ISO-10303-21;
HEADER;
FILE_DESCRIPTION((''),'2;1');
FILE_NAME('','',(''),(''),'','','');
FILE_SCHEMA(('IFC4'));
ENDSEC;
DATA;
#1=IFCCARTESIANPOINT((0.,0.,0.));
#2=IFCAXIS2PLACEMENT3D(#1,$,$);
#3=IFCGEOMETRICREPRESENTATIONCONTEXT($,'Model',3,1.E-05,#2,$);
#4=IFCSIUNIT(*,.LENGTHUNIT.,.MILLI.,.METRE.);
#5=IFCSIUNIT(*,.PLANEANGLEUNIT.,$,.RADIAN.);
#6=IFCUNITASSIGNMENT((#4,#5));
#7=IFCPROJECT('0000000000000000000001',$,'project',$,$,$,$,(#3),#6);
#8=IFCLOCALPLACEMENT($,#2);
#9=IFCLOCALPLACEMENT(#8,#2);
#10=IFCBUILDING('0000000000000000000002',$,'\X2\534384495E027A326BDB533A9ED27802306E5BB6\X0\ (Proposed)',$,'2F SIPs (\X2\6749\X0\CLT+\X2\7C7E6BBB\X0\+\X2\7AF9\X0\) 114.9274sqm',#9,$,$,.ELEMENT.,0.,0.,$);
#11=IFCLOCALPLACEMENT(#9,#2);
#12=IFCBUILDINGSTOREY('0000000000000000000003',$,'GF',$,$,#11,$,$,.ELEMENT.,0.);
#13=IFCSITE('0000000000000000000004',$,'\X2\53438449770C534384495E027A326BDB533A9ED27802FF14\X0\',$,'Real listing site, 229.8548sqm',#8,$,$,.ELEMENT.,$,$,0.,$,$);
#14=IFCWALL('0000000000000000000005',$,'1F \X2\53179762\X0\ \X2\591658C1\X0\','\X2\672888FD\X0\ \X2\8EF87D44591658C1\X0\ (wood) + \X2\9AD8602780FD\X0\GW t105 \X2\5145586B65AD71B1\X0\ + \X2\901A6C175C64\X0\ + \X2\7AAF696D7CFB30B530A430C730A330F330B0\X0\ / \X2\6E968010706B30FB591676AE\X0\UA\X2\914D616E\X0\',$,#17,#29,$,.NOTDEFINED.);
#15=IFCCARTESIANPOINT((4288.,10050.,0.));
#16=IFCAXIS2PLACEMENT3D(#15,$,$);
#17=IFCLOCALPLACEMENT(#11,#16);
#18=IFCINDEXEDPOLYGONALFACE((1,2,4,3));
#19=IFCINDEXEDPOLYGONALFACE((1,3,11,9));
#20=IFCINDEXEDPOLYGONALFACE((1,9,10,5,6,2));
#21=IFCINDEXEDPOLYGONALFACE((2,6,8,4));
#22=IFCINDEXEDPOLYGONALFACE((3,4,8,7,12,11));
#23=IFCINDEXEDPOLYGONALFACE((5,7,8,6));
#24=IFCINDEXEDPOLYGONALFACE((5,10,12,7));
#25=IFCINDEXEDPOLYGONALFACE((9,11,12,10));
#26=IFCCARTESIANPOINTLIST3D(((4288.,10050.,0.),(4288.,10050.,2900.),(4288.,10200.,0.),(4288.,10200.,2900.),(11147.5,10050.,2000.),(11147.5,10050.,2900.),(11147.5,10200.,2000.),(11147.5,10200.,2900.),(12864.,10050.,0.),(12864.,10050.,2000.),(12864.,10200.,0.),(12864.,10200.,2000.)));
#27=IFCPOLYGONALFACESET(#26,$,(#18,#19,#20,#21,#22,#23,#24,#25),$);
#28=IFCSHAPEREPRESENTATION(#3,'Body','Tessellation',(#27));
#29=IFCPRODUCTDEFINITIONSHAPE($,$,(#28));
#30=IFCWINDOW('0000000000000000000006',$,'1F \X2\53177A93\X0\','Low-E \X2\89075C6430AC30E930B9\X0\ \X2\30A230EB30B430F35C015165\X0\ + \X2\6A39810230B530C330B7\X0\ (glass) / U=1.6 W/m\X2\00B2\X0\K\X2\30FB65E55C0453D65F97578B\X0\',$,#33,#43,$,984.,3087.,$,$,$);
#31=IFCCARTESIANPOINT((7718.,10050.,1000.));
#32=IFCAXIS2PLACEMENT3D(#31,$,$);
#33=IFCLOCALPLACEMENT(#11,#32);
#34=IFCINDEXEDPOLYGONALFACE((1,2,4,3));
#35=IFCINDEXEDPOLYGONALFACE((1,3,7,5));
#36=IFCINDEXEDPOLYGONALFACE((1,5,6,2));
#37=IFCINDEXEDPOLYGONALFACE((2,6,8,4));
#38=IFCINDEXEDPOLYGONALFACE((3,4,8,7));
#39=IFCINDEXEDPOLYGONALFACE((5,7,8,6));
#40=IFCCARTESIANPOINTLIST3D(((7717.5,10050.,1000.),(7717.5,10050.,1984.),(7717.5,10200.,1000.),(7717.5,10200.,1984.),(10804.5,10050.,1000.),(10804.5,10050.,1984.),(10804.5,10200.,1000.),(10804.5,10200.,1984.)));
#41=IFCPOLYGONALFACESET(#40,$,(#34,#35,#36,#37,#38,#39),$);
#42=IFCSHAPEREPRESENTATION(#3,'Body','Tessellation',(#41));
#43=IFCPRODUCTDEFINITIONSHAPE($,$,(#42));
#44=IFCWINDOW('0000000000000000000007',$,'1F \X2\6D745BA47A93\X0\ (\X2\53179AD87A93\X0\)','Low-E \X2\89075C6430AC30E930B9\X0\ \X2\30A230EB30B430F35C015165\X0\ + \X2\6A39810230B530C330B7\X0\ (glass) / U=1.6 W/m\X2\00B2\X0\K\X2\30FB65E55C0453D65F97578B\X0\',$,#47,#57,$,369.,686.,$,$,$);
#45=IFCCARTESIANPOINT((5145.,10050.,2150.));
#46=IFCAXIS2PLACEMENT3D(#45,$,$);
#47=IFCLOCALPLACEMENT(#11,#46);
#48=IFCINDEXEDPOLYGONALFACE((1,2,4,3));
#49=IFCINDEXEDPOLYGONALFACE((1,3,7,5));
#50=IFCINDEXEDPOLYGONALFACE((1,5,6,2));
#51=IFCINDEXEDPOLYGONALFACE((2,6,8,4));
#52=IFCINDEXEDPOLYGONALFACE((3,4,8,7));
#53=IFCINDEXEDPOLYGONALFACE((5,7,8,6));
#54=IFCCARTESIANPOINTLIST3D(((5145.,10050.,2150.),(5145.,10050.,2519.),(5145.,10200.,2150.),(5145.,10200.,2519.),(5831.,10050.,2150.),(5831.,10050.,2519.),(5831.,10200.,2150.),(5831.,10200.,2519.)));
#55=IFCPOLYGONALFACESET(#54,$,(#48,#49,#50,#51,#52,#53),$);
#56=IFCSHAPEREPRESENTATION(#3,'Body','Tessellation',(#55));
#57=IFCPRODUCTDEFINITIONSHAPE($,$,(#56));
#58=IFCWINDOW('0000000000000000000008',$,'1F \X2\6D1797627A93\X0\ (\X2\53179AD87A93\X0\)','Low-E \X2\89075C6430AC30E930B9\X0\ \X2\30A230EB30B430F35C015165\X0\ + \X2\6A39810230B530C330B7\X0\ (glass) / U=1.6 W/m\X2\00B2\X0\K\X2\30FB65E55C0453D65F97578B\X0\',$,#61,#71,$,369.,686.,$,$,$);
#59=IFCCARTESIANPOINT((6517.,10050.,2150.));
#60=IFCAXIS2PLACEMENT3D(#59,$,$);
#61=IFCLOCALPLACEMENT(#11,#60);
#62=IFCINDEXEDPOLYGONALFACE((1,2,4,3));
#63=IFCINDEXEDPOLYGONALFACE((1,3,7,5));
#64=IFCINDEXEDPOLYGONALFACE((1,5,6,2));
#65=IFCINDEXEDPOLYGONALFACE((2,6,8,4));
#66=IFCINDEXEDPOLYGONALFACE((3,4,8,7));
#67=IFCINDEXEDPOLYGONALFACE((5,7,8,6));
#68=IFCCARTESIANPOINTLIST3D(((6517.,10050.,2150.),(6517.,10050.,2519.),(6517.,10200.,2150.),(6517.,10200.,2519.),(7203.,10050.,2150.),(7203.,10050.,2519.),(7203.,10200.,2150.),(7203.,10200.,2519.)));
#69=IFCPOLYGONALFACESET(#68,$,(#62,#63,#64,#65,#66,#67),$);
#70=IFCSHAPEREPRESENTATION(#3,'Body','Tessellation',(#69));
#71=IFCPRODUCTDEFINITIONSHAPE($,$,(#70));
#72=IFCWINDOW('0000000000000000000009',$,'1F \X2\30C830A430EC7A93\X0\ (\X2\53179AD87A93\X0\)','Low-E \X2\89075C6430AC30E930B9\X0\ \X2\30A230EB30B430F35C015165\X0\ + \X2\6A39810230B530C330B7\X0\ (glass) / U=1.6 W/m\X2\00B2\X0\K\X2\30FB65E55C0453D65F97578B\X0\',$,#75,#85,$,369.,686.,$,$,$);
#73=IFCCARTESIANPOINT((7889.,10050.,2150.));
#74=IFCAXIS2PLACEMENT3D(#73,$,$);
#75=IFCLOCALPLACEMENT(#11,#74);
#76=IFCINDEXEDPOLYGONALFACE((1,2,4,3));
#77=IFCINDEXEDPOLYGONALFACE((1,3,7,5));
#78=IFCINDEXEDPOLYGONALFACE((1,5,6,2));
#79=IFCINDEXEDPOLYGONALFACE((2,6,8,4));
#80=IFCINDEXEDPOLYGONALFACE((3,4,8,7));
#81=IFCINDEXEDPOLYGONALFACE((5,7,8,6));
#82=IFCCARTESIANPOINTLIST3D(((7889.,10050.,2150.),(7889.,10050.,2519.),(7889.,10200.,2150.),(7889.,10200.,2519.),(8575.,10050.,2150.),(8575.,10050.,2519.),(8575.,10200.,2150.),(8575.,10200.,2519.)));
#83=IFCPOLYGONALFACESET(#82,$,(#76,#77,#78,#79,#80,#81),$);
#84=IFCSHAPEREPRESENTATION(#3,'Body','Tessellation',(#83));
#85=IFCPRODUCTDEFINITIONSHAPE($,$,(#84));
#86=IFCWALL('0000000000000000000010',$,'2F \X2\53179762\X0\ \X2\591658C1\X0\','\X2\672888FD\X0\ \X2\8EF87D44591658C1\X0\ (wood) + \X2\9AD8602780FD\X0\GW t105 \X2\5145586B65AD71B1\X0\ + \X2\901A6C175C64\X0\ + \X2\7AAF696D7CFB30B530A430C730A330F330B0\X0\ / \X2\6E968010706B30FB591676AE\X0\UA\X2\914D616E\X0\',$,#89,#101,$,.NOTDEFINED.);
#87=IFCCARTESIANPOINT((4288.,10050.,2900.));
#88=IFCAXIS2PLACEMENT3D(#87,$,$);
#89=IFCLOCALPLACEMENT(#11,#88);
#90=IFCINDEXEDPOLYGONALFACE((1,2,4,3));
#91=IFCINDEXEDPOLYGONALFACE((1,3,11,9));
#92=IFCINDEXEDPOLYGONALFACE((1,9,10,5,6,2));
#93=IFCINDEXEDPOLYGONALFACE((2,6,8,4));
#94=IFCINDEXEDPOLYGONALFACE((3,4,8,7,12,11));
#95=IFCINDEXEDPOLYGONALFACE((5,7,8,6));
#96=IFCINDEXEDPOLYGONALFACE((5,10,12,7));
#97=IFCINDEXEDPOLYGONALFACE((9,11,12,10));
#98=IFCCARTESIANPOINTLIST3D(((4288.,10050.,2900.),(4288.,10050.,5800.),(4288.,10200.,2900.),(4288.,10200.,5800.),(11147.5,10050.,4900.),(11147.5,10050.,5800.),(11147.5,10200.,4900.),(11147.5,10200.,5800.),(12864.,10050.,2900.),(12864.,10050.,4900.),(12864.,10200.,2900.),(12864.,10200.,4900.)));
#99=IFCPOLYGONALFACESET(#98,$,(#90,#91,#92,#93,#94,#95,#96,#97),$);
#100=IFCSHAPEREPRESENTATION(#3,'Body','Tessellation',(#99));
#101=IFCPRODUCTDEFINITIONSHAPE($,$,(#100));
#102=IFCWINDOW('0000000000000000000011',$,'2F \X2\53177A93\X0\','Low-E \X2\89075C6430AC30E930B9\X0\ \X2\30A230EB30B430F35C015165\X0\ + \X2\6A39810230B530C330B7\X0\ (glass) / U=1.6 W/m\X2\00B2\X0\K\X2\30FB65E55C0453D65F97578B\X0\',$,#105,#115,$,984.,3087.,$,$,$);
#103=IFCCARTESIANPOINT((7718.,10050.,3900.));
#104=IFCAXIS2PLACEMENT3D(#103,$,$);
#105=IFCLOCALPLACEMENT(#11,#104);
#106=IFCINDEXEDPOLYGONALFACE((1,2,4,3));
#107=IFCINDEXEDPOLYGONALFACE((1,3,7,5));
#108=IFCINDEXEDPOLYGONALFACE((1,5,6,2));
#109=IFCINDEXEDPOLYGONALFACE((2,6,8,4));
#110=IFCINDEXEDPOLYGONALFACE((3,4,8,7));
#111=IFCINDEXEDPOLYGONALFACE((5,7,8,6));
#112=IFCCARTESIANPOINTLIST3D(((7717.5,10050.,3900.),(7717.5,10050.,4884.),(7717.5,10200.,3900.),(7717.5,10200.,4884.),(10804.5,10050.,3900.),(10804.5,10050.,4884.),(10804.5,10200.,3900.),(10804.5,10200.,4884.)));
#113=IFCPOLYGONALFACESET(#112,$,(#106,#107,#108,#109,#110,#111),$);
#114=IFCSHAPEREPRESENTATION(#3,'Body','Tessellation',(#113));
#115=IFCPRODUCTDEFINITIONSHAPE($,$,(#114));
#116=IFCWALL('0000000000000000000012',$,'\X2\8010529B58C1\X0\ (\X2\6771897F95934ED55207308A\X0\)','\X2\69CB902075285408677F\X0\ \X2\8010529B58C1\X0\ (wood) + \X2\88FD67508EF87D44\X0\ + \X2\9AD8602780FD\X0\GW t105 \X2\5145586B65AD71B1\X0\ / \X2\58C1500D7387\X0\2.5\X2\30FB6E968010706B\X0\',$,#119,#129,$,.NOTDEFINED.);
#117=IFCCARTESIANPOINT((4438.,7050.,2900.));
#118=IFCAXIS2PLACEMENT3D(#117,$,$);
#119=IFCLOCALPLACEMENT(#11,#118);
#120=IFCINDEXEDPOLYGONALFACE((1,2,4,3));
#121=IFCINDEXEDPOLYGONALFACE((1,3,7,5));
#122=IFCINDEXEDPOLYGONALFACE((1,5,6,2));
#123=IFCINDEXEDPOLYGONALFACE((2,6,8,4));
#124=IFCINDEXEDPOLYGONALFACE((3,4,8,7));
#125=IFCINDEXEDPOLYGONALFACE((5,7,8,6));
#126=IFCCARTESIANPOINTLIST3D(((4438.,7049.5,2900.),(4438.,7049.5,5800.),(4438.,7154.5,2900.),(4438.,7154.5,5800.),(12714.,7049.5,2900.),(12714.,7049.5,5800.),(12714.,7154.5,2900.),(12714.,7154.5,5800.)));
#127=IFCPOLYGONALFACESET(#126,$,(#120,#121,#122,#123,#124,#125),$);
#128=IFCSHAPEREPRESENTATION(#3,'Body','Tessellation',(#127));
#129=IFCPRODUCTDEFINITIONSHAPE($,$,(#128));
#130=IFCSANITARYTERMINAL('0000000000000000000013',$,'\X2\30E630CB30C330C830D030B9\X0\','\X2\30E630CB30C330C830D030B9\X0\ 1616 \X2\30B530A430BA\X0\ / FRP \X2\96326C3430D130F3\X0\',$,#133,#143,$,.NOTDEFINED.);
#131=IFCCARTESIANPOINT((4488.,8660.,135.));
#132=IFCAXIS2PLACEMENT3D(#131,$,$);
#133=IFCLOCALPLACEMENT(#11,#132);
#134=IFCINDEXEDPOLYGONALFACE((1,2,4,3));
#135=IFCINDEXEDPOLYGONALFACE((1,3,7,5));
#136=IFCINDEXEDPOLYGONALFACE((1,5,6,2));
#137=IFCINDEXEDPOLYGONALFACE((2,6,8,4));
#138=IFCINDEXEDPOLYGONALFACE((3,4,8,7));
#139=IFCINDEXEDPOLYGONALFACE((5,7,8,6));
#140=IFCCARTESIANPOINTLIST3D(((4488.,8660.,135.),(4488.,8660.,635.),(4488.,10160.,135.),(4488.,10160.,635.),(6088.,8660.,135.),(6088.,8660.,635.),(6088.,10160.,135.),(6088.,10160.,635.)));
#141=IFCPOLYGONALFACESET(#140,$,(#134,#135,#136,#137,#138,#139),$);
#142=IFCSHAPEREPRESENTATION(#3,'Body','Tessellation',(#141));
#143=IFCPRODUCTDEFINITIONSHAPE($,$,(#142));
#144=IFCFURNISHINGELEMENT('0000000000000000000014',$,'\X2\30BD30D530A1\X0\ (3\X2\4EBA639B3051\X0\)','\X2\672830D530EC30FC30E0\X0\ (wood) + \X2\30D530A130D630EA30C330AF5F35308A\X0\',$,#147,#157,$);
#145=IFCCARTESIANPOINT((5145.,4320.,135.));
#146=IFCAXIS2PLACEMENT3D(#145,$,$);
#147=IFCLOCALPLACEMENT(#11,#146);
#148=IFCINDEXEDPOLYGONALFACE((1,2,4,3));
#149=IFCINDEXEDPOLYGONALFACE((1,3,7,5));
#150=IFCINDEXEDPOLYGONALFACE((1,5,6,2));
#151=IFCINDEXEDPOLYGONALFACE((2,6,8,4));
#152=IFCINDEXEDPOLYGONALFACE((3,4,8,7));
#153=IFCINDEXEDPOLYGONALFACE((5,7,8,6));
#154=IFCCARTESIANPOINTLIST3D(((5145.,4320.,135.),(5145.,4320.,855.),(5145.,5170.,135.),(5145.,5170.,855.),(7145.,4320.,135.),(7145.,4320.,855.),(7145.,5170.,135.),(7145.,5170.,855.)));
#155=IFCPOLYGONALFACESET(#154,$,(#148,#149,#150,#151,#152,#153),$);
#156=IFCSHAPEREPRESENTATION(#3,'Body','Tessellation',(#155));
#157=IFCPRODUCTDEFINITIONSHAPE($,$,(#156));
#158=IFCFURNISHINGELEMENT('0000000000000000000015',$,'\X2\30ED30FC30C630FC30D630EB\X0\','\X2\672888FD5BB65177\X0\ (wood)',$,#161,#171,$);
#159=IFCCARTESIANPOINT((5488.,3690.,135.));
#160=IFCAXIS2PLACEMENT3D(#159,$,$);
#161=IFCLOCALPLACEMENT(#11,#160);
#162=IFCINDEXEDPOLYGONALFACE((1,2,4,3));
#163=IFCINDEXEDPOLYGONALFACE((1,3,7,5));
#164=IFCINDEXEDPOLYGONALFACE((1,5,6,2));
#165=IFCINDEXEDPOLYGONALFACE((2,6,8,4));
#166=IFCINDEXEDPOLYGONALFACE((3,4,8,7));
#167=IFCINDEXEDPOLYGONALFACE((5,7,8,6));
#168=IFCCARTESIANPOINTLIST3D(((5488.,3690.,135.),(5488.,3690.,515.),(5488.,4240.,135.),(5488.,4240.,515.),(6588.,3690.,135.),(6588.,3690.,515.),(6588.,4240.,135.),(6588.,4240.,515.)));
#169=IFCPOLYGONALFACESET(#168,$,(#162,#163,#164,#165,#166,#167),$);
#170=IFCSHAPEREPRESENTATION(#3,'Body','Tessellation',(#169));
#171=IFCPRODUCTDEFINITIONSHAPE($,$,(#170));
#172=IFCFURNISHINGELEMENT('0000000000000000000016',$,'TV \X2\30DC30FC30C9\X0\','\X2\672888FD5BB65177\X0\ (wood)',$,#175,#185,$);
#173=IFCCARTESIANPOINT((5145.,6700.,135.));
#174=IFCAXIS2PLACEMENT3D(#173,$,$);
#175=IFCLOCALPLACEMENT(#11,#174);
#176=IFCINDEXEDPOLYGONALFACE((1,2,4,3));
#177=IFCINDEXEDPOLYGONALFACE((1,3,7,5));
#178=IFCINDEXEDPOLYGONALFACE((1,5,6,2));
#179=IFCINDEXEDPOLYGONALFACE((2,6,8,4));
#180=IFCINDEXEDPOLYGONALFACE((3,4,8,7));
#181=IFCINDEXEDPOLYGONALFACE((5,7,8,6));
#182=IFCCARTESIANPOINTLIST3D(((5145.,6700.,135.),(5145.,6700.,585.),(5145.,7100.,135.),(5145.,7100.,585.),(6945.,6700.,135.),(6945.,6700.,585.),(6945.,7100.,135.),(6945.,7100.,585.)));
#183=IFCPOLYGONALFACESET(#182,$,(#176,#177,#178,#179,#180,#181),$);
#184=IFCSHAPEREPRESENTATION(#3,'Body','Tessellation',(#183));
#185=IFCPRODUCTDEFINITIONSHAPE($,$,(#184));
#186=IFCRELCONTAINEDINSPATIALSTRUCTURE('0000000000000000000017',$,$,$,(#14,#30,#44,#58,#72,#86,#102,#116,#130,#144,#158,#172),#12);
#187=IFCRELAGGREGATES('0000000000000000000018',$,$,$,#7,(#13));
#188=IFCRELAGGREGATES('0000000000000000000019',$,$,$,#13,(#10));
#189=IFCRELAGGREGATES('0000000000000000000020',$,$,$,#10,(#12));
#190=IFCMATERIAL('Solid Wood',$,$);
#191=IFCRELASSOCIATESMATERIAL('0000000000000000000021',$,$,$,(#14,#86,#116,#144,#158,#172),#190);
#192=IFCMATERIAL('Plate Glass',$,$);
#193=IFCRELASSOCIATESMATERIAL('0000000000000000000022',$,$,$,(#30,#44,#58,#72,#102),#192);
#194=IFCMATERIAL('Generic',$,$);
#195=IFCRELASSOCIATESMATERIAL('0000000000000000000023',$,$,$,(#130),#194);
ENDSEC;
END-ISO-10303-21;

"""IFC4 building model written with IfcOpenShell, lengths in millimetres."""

from ifc_helpers import new_model, si_unit, frame, frame_2d, origin, place, context, project, spatial, rectangle, extrude, material, element, fill, save


model = new_model("IFC4")

# Units and contexts
model_context = context("Model", 3, precision=1e-05, world=origin())
ifc_project = project(units=[si_unit("LENGTHUNIT", "METRE", prefix="MILLI"), si_unit("PLANEANGLEUNIT", "RADIAN")], contexts=[model_context])

# Site, building, storey
site_placement = place(None, origin())
site = spatial("IfcSite", under=ifc_project, at=site_placement, Name="千葉県千葉市稲毛区黒砂４", ObjectType="Real listing site, 229.8548sqm", CompositionType="ELEMENT", RefElevation=0.0)
building_placement = place(site_placement, origin())
building = spatial("IfcBuilding", under=site, at=building_placement, Name="千葉市稲毛区黒砂の家 (Proposed)", ObjectType="2F SIPs (杉CLT+籾殻+竹) 114.9274sqm", CompositionType="ELEMENT", ElevationOfRefHeight=0.0, ElevationOfTerrain=0.0)
storey_placement = place(building_placement, origin())
storey = spatial("IfcBuildingStorey", under=building, at=storey_placement, Name="GF", CompositionType="ELEMENT", Elevation=0.0)

# Wall, openings, windows
ifc_material_1 = material(Name="Solid Wood")
wall_1_placement = place(storey_placement, frame((4288.0, 10050.0, 0.0)))
wall_1 = element("IfcWall", 1, at=wall_1_placement, inside=storey, material=ifc_material_1, Name="1F 北面 外壁", Description="木製 軸組外壁 (wood) + 高性能GW t105 充填断熱 + 通気層 + 窯業系サイディング / 準耐火・外皮UA配慮", PredefinedType="NOTDEFINED", context=model_context, shape_type="SweptSolid", body=[
    extrude(rectangle(XDim=8576.0, YDim=150.0, at=frame_2d((4288.0, 75.0))), frame((4288.0, 10050.0, 0.0)), (0.0, 0.0, 1.0), 2900.0),
])
opening_1_placement = place(storey_placement, frame((7718.0, 10050.0, 1000.0)))
opening_1 = element("IfcOpeningElement", 2, at=opening_1_placement, cuts=wall_1, PredefinedType="NOTDEFINED", context=model_context, shape_type="SweptSolid", body=[
    extrude(rectangle(XDim=3087.0, YDim=150.0, at=frame_2d((1543.0, 75.0))), frame((7718.0, 10050.0, 1000.0)), (0.0, 0.0, 1.0), 984.0),
])
opening_2_placement = place(storey_placement, frame((5145.0, 10050.0, 2150.0)))
opening_2 = element("IfcOpeningElement", 3, at=opening_2_placement, cuts=wall_1, PredefinedType="NOTDEFINED", context=model_context, shape_type="SweptSolid", body=[
    extrude(rectangle(XDim=686.0, YDim=150.0, at=frame_2d((343.0, 75.0))), frame((5145.0, 10050.0, 2150.0)), (0.0, 0.0, 1.0), 369.0),
])
opening_3_placement = place(storey_placement, frame((6517.0, 10050.0, 2150.0)))
opening_3 = element("IfcOpeningElement", 4, at=opening_3_placement, cuts=wall_1, PredefinedType="NOTDEFINED", context=model_context, shape_type="SweptSolid", body=[
    extrude(rectangle(XDim=686.0, YDim=150.0, at=frame_2d((343.0, 75.0))), frame((6517.0, 10050.0, 2150.0)), (0.0, 0.0, 1.0), 369.0),
])
opening_4_placement = place(storey_placement, frame((7889.0, 10050.0, 2150.0)))
opening_4 = element("IfcOpeningElement", 5, at=opening_4_placement, cuts=wall_1, PredefinedType="NOTDEFINED", context=model_context, shape_type="SweptSolid", body=[
    extrude(rectangle(XDim=686.0, YDim=150.0, at=frame_2d((343.0, 75.0))), frame((7889.0, 10050.0, 2150.0)), (0.0, 0.0, 1.0), 369.0),
])
ifc_material_2 = material(Name="Plate Glass")
window_1_placement = place(storey_placement, frame((7718.0, 10050.0, 1000.0)))
window_1 = element("IfcWindow", 6, at=window_1_placement, inside=storey, material=ifc_material_2, Name="1F 北窓", Description="Low-E 複層ガラス アルゴン封入 + 樹脂サッシ (glass) / U=1.6 W/m²K・日射取得型", OverallHeight=984.0, OverallWidth=3087.0, context=model_context, shape_type="SweptSolid", body=[
    extrude(rectangle(XDim=3087.0, YDim=150.0, at=frame_2d((1543.0, 75.0))), frame((7718.0, 10050.0, 1000.0)), (0.0, 0.0, 1.0), 984.0),
])
fill(opening_1, window_1)
window_2_placement = place(storey_placement, frame((5145.0, 10050.0, 2150.0)))
window_2 = element("IfcWindow", 7, at=window_2_placement, inside=storey, material=ifc_material_2, Name="1F 浴室窓 (北高窓)", Description="Low-E 複層ガラス アルゴン封入 + 樹脂サッシ (glass) / U=1.6 W/m²K・日射取得型", OverallHeight=369.0, OverallWidth=686.0, context=model_context, shape_type="SweptSolid", body=[
    extrude(rectangle(XDim=686.0, YDim=150.0, at=frame_2d((343.0, 75.0))), frame((5145.0, 10050.0, 2150.0)), (0.0, 0.0, 1.0), 369.0),
])
fill(opening_2, window_2)
window_3_placement = place(storey_placement, frame((6517.0, 10050.0, 2150.0)))
window_3 = element("IfcWindow", 8, at=window_3_placement, inside=storey, material=ifc_material_2, Name="1F 洗面窓 (北高窓)", Description="Low-E 複層ガラス アルゴン封入 + 樹脂サッシ (glass) / U=1.6 W/m²K・日射取得型", OverallHeight=369.0, OverallWidth=686.0, context=model_context, shape_type="SweptSolid", body=[
    extrude(rectangle(XDim=686.0, YDim=150.0, at=frame_2d((343.0, 75.0))), frame((6517.0, 10050.0, 2150.0)), (0.0, 0.0, 1.0), 369.0),
])
fill(opening_3, window_3)
window_4_placement = place(storey_placement, frame((7889.0, 10050.0, 2150.0)))
window_4 = element("IfcWindow", 9, at=window_4_placement, inside=storey, material=ifc_material_2, Name="1F トイレ窓 (北高窓)", Description="Low-E 複層ガラス アルゴン封入 + 樹脂サッシ (glass) / U=1.6 W/m²K・日射取得型", OverallHeight=369.0, OverallWidth=686.0, context=model_context, shape_type="SweptSolid", body=[
    extrude(rectangle(XDim=686.0, YDim=150.0, at=frame_2d((343.0, 75.0))), frame((7889.0, 10050.0, 2150.0)), (0.0, 0.0, 1.0), 369.0),
])
fill(opening_4, window_4)

# Wall, opening, window
wall_2_placement = place(storey_placement, frame((4288.0, 10050.0, 2900.0)))
wall_2 = element("IfcWall", 10, at=wall_2_placement, inside=storey, material=ifc_material_1, Name="2F 北面 外壁", Description="木製 軸組外壁 (wood) + 高性能GW t105 充填断熱 + 通気層 + 窯業系サイディング / 準耐火・外皮UA配慮", PredefinedType="NOTDEFINED", context=model_context, shape_type="SweptSolid", body=[
    extrude(rectangle(XDim=8576.0, YDim=150.0, at=frame_2d((4288.0, 75.0))), frame((4288.0, 10050.0, 2900.0)), (0.0, 0.0, 1.0), 2900.0),
])
opening_5_placement = place(storey_placement, frame((7718.0, 10050.0, 3900.0)))
opening_5 = element("IfcOpeningElement", 11, at=opening_5_placement, cuts=wall_2, PredefinedType="NOTDEFINED", context=model_context, shape_type="SweptSolid", body=[
    extrude(rectangle(XDim=3087.0, YDim=150.0, at=frame_2d((1543.0, 75.0))), frame((7718.0, 10050.0, 3900.0)), (0.0, 0.0, 1.0), 984.0),
])
window_5_placement = place(storey_placement, frame((7718.0, 10050.0, 3900.0)))
window_5 = element("IfcWindow", 12, at=window_5_placement, inside=storey, material=ifc_material_2, Name="2F 北窓", Description="Low-E 複層ガラス アルゴン封入 + 樹脂サッシ (glass) / U=1.6 W/m²K・日射取得型", OverallHeight=984.0, OverallWidth=3087.0, context=model_context, shape_type="SweptSolid", body=[
    extrude(rectangle(XDim=3087.0, YDim=150.0, at=frame_2d((1543.0, 75.0))), frame((7718.0, 10050.0, 3900.0)), (0.0, 0.0, 1.0), 984.0),
])
fill(opening_5, window_5)

# Wall
wall_3_placement = place(storey_placement, frame((4438.0, 7050.0, 2900.0)))
element("IfcWall", 13, at=wall_3_placement, inside=storey, material=ifc_material_1, Name="耐力壁 (東西間仕切り)", Description="構造用合板 耐力壁 (wood) + 製材軸組 + 高性能GW t105 充填断熱 / 壁倍率2.5・準耐火", PredefinedType="NOTDEFINED", context=model_context, shape_type="SweptSolid", body=[
    extrude(rectangle(XDim=8276.0, YDim=105.0, at=frame_2d((4138.0, 52.0))), frame((4438.0, 7050.0, 2900.0)), (0.0, 0.0, 1.0), 2900.0),
])

# Sanitary terminal
ifc_material_3 = material(Name="Generic")
sanitary_terminal_placement = place(storey_placement, frame((4488.0, 8660.0, 135.0)))
element("IfcSanitaryTerminal", 14, at=sanitary_terminal_placement, inside=storey, material=ifc_material_3, Name="ユニットバス", Description="ユニットバス 1616 サイズ / FRP 防水パン", PredefinedType="NOTDEFINED", context=model_context, shape_type="SweptSolid", body=[
    extrude(rectangle(XDim=1600.0, YDim=1500.0, at=frame_2d((800.0, 750.0))), frame((4488.0, 8660.0, 135.0)), (0.0, 0.0, 1.0), 500.0),
])

# Furnishing elements
furnishing_1_placement = place(storey_placement, frame((5145.0, 4320.0, 135.0)))
element("IfcFurnishingElement", 15, at=furnishing_1_placement, inside=storey, material=ifc_material_1, Name="ソファ (3人掛け)", Description="木フレーム (wood) + ファブリック張り", context=model_context, shape_type="SweptSolid", body=[
    extrude(rectangle(XDim=2000.0, YDim=850.0, at=frame_2d((1000.0, 425.0))), frame((5145.0, 4320.0, 135.0)), (0.0, 0.0, 1.0), 720.0),
])
furnishing_2_placement = place(storey_placement, frame((5488.0, 3690.0, 135.0)))
element("IfcFurnishingElement", 16, at=furnishing_2_placement, inside=storey, material=ifc_material_1, Name="ローテーブル", Description="木製家具 (wood)", context=model_context, shape_type="SweptSolid", body=[
    extrude(rectangle(XDim=1100.0, YDim=550.0, at=frame_2d((550.0, 275.0))), frame((5488.0, 3690.0, 135.0)), (0.0, 0.0, 1.0), 380.0),
])
furnishing_3_placement = place(storey_placement, frame((5145.0, 6700.0, 135.0)))
element("IfcFurnishingElement", 17, at=furnishing_3_placement, inside=storey, material=ifc_material_1, Name="TV ボード", Description="木製家具 (wood)", context=model_context, shape_type="SweptSolid", body=[
    extrude(rectangle(XDim=1800.0, YDim=400.0, at=frame_2d((900.0, 200.0))), frame((5145.0, 6700.0, 135.0)), (0.0, 0.0, 1.0), 450.0),
])

save(model, "model.ifc")
